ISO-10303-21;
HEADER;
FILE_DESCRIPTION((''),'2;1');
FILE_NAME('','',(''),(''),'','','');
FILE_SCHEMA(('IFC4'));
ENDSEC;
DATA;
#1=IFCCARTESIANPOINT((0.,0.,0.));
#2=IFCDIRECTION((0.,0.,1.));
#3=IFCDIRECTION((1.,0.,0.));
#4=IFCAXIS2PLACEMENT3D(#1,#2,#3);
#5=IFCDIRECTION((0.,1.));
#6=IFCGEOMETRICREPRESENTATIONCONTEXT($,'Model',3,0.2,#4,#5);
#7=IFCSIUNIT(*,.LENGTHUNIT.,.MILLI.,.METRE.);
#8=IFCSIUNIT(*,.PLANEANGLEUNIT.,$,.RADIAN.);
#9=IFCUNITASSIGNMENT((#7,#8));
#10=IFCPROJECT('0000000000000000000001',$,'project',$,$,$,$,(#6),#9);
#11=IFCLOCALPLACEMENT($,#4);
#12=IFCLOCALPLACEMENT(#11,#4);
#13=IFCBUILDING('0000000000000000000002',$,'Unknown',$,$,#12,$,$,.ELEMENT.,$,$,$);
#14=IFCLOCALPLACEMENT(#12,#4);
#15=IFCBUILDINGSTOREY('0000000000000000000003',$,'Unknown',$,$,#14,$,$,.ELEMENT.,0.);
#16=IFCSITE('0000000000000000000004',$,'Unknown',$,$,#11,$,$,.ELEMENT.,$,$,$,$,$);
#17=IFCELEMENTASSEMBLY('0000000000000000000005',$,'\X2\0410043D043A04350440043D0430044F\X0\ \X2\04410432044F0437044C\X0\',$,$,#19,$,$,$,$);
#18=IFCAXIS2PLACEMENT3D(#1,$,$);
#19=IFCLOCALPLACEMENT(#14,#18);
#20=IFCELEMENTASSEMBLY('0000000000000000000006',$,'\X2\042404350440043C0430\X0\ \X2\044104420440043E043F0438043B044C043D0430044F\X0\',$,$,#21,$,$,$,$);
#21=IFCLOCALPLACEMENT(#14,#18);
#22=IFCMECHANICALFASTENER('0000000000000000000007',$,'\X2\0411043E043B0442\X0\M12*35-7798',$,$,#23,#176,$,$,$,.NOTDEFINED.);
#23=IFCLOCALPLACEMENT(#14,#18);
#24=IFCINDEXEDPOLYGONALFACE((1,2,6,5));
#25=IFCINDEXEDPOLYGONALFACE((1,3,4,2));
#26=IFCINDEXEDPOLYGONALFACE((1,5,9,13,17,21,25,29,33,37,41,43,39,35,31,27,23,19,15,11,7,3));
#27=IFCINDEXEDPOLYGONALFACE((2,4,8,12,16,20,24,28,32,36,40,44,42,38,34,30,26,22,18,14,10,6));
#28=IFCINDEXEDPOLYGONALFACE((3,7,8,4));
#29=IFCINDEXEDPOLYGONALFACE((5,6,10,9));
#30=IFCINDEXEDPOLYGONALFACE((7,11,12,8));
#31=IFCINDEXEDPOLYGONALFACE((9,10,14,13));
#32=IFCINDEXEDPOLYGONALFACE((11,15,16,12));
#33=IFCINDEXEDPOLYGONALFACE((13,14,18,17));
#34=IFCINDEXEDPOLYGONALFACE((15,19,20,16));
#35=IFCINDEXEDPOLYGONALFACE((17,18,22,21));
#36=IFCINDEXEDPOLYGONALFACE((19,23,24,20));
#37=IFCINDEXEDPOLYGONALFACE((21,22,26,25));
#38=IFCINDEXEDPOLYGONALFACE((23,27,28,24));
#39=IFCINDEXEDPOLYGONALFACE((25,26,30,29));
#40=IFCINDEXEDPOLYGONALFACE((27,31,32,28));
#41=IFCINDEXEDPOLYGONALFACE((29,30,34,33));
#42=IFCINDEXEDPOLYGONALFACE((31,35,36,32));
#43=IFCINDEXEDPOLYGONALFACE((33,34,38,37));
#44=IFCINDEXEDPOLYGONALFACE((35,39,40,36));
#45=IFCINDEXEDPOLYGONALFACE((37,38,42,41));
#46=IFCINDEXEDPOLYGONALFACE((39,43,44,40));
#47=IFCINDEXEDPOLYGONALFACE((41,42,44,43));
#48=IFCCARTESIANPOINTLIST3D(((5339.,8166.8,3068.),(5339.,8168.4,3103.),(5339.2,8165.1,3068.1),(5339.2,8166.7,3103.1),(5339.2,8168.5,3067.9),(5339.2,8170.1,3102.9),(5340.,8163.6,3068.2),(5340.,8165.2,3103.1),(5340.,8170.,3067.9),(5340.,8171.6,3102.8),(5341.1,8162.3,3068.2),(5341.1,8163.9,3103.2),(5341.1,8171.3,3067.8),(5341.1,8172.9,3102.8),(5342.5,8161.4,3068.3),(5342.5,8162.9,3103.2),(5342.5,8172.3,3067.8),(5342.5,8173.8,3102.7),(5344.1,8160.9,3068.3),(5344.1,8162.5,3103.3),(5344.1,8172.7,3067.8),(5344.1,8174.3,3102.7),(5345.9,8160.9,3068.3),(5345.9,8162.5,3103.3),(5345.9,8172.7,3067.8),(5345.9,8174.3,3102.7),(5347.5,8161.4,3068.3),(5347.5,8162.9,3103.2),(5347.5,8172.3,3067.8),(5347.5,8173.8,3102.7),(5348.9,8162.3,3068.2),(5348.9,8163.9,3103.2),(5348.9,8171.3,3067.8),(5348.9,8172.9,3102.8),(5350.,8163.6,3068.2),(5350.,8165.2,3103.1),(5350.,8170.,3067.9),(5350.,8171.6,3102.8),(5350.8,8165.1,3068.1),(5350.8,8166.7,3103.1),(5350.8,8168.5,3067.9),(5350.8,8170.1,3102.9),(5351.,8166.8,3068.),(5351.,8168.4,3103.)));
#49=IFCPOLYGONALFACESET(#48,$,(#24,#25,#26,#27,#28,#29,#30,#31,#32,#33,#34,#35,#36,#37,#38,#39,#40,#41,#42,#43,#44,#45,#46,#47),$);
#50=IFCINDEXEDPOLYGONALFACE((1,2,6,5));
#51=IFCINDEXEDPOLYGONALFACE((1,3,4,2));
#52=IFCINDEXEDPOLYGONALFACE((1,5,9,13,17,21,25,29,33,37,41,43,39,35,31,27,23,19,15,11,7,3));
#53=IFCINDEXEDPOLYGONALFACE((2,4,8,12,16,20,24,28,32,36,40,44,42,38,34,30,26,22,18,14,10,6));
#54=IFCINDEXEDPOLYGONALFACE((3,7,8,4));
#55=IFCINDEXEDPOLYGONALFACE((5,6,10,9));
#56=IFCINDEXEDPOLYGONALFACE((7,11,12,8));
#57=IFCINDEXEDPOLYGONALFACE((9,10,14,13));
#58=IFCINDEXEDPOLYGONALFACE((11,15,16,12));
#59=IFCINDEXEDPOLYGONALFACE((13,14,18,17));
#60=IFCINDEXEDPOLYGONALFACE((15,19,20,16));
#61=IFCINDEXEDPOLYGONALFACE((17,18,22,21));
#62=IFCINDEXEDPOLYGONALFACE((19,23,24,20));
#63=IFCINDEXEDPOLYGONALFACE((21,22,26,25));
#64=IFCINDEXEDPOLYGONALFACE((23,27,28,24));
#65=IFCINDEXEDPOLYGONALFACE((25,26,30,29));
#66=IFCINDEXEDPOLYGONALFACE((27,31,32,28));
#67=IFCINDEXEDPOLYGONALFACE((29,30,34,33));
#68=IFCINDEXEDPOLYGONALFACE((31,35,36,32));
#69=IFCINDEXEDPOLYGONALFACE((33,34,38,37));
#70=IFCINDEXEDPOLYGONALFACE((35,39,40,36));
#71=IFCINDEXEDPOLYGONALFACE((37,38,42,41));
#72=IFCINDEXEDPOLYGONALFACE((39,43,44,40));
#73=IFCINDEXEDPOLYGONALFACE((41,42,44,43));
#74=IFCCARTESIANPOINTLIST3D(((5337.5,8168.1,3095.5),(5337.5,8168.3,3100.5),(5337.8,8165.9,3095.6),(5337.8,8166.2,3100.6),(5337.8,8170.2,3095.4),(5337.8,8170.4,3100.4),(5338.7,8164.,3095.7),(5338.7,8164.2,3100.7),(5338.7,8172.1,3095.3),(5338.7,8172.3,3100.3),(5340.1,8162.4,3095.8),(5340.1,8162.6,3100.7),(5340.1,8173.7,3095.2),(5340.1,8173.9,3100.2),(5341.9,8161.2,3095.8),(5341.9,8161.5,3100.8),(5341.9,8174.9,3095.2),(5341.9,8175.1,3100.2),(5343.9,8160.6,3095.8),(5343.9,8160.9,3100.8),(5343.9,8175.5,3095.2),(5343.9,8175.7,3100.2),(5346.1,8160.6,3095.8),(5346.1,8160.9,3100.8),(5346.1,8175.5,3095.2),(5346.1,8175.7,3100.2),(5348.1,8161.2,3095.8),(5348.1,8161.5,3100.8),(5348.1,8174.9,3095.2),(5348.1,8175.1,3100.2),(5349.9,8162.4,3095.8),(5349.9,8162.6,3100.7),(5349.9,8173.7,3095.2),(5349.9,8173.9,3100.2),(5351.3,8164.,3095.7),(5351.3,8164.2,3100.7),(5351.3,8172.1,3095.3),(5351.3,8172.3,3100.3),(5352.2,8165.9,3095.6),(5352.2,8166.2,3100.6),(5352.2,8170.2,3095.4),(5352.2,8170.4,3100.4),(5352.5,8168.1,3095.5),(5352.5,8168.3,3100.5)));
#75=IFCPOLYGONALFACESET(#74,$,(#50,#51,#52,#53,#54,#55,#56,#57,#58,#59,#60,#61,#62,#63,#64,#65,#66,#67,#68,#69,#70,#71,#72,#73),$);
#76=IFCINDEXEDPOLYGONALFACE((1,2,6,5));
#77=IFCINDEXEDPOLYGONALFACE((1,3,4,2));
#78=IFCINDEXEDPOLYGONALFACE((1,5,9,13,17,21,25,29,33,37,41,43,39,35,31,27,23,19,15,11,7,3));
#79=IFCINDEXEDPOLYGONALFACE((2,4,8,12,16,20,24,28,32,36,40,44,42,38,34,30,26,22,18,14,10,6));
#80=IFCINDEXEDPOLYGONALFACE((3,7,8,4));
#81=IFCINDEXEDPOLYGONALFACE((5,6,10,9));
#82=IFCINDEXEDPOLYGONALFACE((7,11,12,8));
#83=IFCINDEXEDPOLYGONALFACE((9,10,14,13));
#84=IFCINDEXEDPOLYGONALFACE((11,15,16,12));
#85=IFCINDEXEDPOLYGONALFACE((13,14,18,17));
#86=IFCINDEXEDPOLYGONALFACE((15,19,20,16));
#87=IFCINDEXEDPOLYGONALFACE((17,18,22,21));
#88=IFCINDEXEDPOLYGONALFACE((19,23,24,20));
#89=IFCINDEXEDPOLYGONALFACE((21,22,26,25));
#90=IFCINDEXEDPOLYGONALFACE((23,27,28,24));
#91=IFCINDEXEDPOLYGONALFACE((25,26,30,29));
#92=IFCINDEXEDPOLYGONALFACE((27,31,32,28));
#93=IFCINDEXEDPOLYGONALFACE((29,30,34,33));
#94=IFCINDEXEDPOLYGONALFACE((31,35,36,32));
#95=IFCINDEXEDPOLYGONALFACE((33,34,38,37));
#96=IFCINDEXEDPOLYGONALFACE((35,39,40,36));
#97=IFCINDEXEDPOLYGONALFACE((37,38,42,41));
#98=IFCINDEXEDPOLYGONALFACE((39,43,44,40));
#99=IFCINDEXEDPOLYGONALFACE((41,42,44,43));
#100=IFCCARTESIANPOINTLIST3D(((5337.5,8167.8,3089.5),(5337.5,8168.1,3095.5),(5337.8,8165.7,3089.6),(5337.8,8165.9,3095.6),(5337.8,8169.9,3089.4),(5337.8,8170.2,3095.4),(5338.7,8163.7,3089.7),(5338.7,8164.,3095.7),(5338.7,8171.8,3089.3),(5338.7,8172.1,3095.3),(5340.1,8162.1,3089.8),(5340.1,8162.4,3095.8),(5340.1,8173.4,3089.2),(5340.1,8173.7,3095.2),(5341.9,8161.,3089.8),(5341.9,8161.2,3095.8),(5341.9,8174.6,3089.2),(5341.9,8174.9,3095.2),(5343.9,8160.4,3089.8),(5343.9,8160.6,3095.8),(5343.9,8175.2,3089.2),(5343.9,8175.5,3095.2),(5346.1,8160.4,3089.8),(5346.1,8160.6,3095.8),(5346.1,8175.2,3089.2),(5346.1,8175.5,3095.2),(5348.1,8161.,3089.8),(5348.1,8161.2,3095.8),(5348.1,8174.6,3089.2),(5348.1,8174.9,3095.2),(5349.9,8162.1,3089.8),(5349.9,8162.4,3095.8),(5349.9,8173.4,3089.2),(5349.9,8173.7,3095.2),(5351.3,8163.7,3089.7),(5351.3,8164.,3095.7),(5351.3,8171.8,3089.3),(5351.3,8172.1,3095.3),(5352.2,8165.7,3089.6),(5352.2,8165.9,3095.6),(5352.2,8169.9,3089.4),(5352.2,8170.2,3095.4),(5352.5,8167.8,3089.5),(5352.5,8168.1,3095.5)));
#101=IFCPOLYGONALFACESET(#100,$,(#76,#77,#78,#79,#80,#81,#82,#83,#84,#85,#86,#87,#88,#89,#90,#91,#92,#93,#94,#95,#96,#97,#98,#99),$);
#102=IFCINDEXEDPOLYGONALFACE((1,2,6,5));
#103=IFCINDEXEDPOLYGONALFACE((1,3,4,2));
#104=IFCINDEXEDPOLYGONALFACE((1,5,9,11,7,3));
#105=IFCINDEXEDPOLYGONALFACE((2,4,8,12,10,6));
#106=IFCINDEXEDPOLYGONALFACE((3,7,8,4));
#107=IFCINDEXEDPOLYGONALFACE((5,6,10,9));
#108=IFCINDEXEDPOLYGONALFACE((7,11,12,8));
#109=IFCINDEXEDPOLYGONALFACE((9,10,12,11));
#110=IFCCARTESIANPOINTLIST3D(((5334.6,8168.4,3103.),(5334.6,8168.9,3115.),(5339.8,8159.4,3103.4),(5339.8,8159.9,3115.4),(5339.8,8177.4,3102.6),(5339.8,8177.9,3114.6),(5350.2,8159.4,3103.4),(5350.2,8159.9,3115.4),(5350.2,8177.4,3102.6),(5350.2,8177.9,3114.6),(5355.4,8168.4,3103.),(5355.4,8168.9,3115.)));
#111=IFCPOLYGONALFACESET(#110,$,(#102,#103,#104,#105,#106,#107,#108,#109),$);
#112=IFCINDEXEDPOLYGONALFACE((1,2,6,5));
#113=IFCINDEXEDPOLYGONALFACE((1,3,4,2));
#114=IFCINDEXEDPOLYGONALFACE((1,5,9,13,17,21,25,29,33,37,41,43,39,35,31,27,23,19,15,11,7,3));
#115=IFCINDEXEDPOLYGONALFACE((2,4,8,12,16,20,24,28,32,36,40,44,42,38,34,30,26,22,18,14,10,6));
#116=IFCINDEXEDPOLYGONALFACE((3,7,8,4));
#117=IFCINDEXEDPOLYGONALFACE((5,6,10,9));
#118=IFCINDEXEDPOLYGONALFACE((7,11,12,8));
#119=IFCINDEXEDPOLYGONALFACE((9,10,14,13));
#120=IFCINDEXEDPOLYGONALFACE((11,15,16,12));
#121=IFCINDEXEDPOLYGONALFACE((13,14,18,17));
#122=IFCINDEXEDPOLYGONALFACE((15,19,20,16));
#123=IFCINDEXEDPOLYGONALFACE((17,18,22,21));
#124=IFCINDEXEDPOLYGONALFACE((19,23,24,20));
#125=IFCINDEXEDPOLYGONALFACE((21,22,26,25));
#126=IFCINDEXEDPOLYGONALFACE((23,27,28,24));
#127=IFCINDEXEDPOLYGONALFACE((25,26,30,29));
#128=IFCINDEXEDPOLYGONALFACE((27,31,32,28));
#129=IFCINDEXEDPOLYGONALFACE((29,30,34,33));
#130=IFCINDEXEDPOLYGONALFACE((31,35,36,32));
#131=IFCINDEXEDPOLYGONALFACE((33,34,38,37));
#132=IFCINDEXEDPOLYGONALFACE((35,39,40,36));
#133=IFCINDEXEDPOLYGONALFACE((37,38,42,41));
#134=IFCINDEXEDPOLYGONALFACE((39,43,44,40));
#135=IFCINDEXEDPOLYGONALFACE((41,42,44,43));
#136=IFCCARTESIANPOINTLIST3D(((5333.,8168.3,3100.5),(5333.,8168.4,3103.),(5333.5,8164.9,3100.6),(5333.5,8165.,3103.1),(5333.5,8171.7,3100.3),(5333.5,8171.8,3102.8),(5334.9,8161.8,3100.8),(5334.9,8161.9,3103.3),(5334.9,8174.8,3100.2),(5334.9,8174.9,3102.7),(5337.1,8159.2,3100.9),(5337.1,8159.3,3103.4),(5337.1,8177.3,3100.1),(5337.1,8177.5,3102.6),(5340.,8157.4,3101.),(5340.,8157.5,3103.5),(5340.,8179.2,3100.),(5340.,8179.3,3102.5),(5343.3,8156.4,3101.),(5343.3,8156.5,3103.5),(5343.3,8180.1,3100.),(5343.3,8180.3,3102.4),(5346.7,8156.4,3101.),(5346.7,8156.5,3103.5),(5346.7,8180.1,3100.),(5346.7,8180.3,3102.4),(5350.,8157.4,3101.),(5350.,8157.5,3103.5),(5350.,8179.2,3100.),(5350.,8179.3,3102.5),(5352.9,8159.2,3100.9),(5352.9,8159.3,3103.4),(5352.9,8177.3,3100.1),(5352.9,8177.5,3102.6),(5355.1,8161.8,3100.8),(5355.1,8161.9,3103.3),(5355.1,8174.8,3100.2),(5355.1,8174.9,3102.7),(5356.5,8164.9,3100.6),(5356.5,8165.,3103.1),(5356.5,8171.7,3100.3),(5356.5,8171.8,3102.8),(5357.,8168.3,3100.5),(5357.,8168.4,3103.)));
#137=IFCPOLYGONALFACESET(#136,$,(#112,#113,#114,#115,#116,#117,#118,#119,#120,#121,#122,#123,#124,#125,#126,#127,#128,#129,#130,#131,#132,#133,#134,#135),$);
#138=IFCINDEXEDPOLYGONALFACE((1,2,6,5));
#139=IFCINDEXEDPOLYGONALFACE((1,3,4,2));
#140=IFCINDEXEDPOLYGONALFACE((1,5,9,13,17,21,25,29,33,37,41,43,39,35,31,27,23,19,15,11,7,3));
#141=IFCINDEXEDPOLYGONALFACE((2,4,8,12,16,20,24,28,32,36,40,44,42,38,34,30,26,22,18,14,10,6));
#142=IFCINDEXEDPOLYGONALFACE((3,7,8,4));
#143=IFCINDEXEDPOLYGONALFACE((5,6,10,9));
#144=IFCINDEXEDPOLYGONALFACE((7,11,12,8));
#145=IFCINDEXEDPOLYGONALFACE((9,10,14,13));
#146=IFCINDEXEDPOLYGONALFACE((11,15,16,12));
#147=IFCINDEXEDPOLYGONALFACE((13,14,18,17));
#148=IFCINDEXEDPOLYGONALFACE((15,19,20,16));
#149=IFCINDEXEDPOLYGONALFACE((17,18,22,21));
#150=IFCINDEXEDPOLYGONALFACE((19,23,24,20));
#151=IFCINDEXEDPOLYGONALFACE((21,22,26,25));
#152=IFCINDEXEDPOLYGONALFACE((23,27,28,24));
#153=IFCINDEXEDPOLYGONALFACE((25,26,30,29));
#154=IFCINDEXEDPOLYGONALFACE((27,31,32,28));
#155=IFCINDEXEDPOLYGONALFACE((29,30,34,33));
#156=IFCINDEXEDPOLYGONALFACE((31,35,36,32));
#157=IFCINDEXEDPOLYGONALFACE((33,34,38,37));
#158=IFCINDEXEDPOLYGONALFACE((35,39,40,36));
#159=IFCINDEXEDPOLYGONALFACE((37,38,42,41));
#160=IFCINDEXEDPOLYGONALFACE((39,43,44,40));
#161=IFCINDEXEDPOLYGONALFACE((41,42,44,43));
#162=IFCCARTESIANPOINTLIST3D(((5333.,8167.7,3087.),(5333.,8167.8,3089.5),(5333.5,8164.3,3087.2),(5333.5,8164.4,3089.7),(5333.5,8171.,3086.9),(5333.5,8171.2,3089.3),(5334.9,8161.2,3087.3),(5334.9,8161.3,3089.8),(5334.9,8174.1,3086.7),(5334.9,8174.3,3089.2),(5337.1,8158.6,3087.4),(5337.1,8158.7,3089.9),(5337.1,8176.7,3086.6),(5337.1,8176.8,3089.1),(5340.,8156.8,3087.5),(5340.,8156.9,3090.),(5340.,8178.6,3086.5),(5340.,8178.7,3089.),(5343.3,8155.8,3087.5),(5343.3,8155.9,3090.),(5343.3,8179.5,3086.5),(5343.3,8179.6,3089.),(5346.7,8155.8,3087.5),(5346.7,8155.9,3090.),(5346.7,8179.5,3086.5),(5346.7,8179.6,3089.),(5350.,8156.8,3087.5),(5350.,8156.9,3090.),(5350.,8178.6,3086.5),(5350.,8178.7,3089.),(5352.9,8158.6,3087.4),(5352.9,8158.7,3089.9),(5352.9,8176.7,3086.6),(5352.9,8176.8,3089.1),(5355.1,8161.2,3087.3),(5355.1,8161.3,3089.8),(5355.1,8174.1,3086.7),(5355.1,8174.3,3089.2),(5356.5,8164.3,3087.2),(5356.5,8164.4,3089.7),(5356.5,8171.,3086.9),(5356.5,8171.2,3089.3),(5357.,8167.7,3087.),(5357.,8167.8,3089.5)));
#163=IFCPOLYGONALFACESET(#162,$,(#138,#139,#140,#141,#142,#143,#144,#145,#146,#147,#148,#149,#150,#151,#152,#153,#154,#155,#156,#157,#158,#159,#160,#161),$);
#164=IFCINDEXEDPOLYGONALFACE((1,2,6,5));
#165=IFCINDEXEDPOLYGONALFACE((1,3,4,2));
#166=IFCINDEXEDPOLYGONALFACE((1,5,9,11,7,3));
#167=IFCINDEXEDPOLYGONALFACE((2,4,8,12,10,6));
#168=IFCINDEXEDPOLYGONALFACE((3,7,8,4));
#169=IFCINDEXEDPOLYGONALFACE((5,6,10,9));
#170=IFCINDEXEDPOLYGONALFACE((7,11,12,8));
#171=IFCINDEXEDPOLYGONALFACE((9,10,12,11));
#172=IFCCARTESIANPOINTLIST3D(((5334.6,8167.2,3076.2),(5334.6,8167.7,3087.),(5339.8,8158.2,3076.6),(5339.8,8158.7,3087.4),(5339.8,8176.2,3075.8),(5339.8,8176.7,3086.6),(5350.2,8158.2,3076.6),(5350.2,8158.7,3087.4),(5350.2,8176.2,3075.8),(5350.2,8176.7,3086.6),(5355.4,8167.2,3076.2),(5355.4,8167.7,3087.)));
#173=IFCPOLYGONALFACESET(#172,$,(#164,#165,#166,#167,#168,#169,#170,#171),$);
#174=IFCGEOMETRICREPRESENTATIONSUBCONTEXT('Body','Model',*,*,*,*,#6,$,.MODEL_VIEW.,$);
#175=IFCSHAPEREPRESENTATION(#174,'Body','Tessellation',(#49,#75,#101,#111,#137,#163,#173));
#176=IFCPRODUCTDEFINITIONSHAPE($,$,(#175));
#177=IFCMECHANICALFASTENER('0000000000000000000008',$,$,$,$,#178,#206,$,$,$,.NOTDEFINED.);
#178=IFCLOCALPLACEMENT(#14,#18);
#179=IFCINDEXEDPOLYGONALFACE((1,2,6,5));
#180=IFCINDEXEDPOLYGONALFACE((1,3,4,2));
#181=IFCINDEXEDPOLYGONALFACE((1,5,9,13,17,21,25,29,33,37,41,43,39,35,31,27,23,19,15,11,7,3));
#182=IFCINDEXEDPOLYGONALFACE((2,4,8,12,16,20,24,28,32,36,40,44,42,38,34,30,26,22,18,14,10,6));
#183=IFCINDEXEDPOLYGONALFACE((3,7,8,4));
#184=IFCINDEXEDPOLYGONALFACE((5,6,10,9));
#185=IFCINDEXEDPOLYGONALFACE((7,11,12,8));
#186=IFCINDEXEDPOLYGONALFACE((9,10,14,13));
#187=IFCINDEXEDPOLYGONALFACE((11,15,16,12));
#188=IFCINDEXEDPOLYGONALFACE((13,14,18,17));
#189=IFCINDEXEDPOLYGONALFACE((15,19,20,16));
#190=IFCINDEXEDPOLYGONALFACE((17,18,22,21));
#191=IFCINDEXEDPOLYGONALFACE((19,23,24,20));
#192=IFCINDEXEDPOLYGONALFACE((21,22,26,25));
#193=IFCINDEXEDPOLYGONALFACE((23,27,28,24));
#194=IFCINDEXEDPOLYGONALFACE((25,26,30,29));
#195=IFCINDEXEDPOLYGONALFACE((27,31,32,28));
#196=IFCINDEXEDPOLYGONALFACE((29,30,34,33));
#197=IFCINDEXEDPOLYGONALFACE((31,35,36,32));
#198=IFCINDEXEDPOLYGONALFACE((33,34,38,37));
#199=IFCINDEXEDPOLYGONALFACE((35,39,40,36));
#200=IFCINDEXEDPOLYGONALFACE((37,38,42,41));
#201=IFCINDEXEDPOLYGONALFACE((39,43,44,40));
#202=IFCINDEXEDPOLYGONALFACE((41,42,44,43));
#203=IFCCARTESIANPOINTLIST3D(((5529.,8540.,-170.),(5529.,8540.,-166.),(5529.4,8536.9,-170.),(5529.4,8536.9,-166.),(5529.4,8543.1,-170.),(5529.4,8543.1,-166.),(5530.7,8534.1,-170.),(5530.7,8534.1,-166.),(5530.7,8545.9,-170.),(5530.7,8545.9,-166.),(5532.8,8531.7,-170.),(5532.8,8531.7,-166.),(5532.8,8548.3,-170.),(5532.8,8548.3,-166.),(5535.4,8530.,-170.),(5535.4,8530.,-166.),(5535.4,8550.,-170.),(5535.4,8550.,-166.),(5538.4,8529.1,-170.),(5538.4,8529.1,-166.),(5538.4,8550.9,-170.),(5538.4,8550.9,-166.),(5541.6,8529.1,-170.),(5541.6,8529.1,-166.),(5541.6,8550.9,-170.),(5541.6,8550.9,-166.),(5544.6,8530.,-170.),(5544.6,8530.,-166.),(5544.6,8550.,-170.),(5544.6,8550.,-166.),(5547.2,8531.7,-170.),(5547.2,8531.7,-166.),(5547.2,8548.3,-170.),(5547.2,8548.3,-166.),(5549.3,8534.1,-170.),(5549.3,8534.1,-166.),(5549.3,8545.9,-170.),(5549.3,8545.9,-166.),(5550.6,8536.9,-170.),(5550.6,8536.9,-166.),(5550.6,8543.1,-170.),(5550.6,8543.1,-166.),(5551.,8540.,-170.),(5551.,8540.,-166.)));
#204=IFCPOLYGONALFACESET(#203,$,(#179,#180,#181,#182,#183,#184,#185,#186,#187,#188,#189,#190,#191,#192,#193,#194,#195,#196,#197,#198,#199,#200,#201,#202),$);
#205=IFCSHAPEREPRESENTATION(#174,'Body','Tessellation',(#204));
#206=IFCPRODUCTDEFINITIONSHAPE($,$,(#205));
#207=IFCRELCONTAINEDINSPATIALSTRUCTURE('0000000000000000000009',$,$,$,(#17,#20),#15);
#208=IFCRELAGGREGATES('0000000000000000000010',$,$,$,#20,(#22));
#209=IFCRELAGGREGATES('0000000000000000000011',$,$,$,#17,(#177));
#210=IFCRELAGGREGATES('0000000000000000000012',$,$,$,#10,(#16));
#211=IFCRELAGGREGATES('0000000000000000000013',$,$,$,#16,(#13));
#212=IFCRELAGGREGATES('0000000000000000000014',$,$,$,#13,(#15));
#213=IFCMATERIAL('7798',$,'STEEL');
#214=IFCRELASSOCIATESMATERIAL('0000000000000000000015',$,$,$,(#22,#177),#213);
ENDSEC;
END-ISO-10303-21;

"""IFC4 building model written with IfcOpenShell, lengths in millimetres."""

from ifc_helpers import new_model, si_unit, direction, frame, origin_with_axes, place, context, subcontext, project, spatial, line, arc, indexed_curve, outline, extrude, source, transform, mapped, material, element, aggregate, save


model = new_model("IFC4")

# Units and contexts
model_context = context("Model", 3, precision=0.2, world=origin_with_axes(), true_north=direction((0.0, 1.0)))
body_context = subcontext(model_context, "Body", "Model", "MODEL_VIEW")
ifc_project = project(units=[si_unit("LENGTHUNIT", "METRE", prefix="MILLI"), si_unit("PLANEANGLEUNIT", "RADIAN")], contexts=[model_context])

# Site, building, storey
site_placement = place(None, origin_with_axes())
site = spatial("IfcSite", under=ifc_project, at=site_placement, Name="Unknown", CompositionType="ELEMENT")
building_placement = place(site_placement, origin_with_axes())
building = spatial("IfcBuilding", under=site, at=building_placement, Name="Unknown", CompositionType="ELEMENT")
storey_placement = place(building_placement, origin_with_axes())
storey = spatial("IfcBuildingStorey", under=building, at=storey_placement, Name="Unknown", CompositionType="ELEMENT", Elevation=0.0)

# Element assembly
assembly_1_placement = place(storey_placement, frame((5540.0, 8540.0, -125.0), z_axis=(-1.0, 0.0, 0.0), x_axis=(0.0, 0.0, -1.0)))
assembly_1 = element("IfcElementAssembly", 1, at=assembly_1_placement, inside=storey, Name="Анкерная связь")

# Element assembly
assembly_2_placement = place(storey_placement, frame((5400.0, 88.6, 3426.7), z_axis=(1.0, 0.0, 0.0), x_axis=(0.0, 0.998969, -0.045408)))
assembly_2 = element("IfcElementAssembly", 2, at=assembly_2_placement, inside=storey, Name="Ферма стропильная")

# Mechanical fasteners
ifc_material_1 = material(Name="7798", Category="STEEL")
shared_shape_1 = source(origin_with_axes(), body_context, "Body", "SweptSolid", [
    extrude(outline(indexed_curve([(6.0, 0.0), (0.0, 6.0), (-6.0, 0.0), (0.0, -6.0)], segments=[arc(1, 2, 3), arc(3, 4, 1)])), frame((0.0, 0.0, 7.5), z_axis=(0.0, 0.0, -1.0), x_axis=(0.0, 1.0, 0.0)), (0.0, 0.0, 1.0), 35.0),
    extrude(outline(indexed_curve([(7.5, 0.0), (0.0, 7.5), (-7.5, 0.0), (0.0, -7.5)], segments=[arc(1, 2, 3), arc(3, 4, 1)])), frame((0.0, 0.0, 5.0), z_axis=(0.0, 0.0, -1.0), x_axis=(0.0, 1.0, 0.0)), (0.0, 0.0, 1.0), 5.0),
    extrude(outline(indexed_curve([(7.5, 0.0), (0.0, 7.5), (-7.5, 0.0), (0.0, -7.5)], segments=[arc(1, 2, 3), arc(3, 4, 1)])), frame((0.0, 0.0, 0.0), z_axis=(0.0, 0.0, -1.0), x_axis=(0.0, 1.0, 0.0)), (0.0, 0.0, 1.0), 6.0),
    extrude(outline(indexed_curve([(10.4, 0.0), (5.2, 9.0), (-5.2, 9.0), (-10.4, 0.0), (-5.2, -9.0), (5.2, -9.0)], segments=[line(1, 2, 3, 4, 5, 6, 1)])), frame((0.0, 0.0, 19.5), z_axis=(0.0, 0.0, -1.0), x_axis=(0.0, 1.0, 0.0)), (0.0, 0.0, 1.0), 12.0),
    extrude(outline(indexed_curve([(12.0, 0.0), (0.0, 12.0), (-12.0, 0.0), (0.0, -12.0)], segments=[arc(1, 2, 3), arc(3, 4, 1)])), frame((0.0, 0.0, 7.5), z_axis=(0.0, 0.0, -1.0), x_axis=(0.0, 1.0, 0.0)), (0.0, 0.0, 1.0), 2.5),
    extrude(outline(indexed_curve([(12.0, 0.0), (0.0, 12.0), (-12.0, 0.0), (0.0, -12.0)], segments=[arc(1, 2, 3), arc(3, 4, 1)])), frame((0.0, 0.0, -6.0), z_axis=(0.0, 0.0, -1.0), x_axis=(0.0, 1.0, 0.0)), (0.0, 0.0, 1.0), 2.5),
    extrude(outline(indexed_curve([(10.4, 0.0), (5.2, 9.0), (-5.2, 9.0), (-10.4, 0.0), (-5.2, -9.0), (5.2, -9.0)], segments=[line(1, 2, 3, 4, 5, 6, 1)])), frame((0.0, 0.0, -8.5), z_axis=(0.0, 0.0, -1.0), x_axis=(0.0, 1.0, 0.0)), (0.0, 0.0, 1.0), 10.8),
])
mechanical_fastener_1_placement = place(assembly_2_placement, frame((8086.1, 36.0, -55.0), z_axis=(0.0, 1.0, 0.0), x_axis=(1.0, 0.0, 0.0)))
mechanical_fastener_1 = element("IfcMechanicalFastener", 3, at=mechanical_fastener_1_placement, material=ifc_material_1, Name="БолтM12*35-7798", PredefinedType="NOTDEFINED", context=body_context, shape_type="MappedRepresentation", body=[
    mapped(shared_shape_1, transform((0.0, 0.0, 0.0))),
])
aggregate(assembly_2, [mechanical_fastener_1])
shared_shape_2 = source(origin_with_axes(), body_context, "Body", "SweptSolid", [
    extrude(outline(indexed_curve([(11.0, 0.0), (0.0, 11.0), (-11.0, 0.0), (0.0, -11.0)], segments=[arc(1, 2, 3), arc(3, 4, 1)])), frame((0.0, 0.0, 4.0), z_axis=(0.0, 0.0, -1.0), x_axis=(0.0, 1.0, 0.0)), (0.0, 0.0, 1.0), 4.0),
])
mechanical_fastener_2_placement = place(assembly_1_placement, frame((41.0, 0.0, 0.0), z_axis=(1.0, 0.0, 0.0), x_axis=(0.0, -1.0, 0.0)))
mechanical_fastener_2 = element("IfcMechanicalFastener", 4, at=mechanical_fastener_2_placement, material=ifc_material_1, PredefinedType="NOTDEFINED", context=body_context, shape_type="MappedRepresentation", body=[
    mapped(shared_shape_2, transform((0.0, 0.0, 0.0))),
])
aggregate(assembly_1, [mechanical_fastener_2])

save(model, "model.ifc")
